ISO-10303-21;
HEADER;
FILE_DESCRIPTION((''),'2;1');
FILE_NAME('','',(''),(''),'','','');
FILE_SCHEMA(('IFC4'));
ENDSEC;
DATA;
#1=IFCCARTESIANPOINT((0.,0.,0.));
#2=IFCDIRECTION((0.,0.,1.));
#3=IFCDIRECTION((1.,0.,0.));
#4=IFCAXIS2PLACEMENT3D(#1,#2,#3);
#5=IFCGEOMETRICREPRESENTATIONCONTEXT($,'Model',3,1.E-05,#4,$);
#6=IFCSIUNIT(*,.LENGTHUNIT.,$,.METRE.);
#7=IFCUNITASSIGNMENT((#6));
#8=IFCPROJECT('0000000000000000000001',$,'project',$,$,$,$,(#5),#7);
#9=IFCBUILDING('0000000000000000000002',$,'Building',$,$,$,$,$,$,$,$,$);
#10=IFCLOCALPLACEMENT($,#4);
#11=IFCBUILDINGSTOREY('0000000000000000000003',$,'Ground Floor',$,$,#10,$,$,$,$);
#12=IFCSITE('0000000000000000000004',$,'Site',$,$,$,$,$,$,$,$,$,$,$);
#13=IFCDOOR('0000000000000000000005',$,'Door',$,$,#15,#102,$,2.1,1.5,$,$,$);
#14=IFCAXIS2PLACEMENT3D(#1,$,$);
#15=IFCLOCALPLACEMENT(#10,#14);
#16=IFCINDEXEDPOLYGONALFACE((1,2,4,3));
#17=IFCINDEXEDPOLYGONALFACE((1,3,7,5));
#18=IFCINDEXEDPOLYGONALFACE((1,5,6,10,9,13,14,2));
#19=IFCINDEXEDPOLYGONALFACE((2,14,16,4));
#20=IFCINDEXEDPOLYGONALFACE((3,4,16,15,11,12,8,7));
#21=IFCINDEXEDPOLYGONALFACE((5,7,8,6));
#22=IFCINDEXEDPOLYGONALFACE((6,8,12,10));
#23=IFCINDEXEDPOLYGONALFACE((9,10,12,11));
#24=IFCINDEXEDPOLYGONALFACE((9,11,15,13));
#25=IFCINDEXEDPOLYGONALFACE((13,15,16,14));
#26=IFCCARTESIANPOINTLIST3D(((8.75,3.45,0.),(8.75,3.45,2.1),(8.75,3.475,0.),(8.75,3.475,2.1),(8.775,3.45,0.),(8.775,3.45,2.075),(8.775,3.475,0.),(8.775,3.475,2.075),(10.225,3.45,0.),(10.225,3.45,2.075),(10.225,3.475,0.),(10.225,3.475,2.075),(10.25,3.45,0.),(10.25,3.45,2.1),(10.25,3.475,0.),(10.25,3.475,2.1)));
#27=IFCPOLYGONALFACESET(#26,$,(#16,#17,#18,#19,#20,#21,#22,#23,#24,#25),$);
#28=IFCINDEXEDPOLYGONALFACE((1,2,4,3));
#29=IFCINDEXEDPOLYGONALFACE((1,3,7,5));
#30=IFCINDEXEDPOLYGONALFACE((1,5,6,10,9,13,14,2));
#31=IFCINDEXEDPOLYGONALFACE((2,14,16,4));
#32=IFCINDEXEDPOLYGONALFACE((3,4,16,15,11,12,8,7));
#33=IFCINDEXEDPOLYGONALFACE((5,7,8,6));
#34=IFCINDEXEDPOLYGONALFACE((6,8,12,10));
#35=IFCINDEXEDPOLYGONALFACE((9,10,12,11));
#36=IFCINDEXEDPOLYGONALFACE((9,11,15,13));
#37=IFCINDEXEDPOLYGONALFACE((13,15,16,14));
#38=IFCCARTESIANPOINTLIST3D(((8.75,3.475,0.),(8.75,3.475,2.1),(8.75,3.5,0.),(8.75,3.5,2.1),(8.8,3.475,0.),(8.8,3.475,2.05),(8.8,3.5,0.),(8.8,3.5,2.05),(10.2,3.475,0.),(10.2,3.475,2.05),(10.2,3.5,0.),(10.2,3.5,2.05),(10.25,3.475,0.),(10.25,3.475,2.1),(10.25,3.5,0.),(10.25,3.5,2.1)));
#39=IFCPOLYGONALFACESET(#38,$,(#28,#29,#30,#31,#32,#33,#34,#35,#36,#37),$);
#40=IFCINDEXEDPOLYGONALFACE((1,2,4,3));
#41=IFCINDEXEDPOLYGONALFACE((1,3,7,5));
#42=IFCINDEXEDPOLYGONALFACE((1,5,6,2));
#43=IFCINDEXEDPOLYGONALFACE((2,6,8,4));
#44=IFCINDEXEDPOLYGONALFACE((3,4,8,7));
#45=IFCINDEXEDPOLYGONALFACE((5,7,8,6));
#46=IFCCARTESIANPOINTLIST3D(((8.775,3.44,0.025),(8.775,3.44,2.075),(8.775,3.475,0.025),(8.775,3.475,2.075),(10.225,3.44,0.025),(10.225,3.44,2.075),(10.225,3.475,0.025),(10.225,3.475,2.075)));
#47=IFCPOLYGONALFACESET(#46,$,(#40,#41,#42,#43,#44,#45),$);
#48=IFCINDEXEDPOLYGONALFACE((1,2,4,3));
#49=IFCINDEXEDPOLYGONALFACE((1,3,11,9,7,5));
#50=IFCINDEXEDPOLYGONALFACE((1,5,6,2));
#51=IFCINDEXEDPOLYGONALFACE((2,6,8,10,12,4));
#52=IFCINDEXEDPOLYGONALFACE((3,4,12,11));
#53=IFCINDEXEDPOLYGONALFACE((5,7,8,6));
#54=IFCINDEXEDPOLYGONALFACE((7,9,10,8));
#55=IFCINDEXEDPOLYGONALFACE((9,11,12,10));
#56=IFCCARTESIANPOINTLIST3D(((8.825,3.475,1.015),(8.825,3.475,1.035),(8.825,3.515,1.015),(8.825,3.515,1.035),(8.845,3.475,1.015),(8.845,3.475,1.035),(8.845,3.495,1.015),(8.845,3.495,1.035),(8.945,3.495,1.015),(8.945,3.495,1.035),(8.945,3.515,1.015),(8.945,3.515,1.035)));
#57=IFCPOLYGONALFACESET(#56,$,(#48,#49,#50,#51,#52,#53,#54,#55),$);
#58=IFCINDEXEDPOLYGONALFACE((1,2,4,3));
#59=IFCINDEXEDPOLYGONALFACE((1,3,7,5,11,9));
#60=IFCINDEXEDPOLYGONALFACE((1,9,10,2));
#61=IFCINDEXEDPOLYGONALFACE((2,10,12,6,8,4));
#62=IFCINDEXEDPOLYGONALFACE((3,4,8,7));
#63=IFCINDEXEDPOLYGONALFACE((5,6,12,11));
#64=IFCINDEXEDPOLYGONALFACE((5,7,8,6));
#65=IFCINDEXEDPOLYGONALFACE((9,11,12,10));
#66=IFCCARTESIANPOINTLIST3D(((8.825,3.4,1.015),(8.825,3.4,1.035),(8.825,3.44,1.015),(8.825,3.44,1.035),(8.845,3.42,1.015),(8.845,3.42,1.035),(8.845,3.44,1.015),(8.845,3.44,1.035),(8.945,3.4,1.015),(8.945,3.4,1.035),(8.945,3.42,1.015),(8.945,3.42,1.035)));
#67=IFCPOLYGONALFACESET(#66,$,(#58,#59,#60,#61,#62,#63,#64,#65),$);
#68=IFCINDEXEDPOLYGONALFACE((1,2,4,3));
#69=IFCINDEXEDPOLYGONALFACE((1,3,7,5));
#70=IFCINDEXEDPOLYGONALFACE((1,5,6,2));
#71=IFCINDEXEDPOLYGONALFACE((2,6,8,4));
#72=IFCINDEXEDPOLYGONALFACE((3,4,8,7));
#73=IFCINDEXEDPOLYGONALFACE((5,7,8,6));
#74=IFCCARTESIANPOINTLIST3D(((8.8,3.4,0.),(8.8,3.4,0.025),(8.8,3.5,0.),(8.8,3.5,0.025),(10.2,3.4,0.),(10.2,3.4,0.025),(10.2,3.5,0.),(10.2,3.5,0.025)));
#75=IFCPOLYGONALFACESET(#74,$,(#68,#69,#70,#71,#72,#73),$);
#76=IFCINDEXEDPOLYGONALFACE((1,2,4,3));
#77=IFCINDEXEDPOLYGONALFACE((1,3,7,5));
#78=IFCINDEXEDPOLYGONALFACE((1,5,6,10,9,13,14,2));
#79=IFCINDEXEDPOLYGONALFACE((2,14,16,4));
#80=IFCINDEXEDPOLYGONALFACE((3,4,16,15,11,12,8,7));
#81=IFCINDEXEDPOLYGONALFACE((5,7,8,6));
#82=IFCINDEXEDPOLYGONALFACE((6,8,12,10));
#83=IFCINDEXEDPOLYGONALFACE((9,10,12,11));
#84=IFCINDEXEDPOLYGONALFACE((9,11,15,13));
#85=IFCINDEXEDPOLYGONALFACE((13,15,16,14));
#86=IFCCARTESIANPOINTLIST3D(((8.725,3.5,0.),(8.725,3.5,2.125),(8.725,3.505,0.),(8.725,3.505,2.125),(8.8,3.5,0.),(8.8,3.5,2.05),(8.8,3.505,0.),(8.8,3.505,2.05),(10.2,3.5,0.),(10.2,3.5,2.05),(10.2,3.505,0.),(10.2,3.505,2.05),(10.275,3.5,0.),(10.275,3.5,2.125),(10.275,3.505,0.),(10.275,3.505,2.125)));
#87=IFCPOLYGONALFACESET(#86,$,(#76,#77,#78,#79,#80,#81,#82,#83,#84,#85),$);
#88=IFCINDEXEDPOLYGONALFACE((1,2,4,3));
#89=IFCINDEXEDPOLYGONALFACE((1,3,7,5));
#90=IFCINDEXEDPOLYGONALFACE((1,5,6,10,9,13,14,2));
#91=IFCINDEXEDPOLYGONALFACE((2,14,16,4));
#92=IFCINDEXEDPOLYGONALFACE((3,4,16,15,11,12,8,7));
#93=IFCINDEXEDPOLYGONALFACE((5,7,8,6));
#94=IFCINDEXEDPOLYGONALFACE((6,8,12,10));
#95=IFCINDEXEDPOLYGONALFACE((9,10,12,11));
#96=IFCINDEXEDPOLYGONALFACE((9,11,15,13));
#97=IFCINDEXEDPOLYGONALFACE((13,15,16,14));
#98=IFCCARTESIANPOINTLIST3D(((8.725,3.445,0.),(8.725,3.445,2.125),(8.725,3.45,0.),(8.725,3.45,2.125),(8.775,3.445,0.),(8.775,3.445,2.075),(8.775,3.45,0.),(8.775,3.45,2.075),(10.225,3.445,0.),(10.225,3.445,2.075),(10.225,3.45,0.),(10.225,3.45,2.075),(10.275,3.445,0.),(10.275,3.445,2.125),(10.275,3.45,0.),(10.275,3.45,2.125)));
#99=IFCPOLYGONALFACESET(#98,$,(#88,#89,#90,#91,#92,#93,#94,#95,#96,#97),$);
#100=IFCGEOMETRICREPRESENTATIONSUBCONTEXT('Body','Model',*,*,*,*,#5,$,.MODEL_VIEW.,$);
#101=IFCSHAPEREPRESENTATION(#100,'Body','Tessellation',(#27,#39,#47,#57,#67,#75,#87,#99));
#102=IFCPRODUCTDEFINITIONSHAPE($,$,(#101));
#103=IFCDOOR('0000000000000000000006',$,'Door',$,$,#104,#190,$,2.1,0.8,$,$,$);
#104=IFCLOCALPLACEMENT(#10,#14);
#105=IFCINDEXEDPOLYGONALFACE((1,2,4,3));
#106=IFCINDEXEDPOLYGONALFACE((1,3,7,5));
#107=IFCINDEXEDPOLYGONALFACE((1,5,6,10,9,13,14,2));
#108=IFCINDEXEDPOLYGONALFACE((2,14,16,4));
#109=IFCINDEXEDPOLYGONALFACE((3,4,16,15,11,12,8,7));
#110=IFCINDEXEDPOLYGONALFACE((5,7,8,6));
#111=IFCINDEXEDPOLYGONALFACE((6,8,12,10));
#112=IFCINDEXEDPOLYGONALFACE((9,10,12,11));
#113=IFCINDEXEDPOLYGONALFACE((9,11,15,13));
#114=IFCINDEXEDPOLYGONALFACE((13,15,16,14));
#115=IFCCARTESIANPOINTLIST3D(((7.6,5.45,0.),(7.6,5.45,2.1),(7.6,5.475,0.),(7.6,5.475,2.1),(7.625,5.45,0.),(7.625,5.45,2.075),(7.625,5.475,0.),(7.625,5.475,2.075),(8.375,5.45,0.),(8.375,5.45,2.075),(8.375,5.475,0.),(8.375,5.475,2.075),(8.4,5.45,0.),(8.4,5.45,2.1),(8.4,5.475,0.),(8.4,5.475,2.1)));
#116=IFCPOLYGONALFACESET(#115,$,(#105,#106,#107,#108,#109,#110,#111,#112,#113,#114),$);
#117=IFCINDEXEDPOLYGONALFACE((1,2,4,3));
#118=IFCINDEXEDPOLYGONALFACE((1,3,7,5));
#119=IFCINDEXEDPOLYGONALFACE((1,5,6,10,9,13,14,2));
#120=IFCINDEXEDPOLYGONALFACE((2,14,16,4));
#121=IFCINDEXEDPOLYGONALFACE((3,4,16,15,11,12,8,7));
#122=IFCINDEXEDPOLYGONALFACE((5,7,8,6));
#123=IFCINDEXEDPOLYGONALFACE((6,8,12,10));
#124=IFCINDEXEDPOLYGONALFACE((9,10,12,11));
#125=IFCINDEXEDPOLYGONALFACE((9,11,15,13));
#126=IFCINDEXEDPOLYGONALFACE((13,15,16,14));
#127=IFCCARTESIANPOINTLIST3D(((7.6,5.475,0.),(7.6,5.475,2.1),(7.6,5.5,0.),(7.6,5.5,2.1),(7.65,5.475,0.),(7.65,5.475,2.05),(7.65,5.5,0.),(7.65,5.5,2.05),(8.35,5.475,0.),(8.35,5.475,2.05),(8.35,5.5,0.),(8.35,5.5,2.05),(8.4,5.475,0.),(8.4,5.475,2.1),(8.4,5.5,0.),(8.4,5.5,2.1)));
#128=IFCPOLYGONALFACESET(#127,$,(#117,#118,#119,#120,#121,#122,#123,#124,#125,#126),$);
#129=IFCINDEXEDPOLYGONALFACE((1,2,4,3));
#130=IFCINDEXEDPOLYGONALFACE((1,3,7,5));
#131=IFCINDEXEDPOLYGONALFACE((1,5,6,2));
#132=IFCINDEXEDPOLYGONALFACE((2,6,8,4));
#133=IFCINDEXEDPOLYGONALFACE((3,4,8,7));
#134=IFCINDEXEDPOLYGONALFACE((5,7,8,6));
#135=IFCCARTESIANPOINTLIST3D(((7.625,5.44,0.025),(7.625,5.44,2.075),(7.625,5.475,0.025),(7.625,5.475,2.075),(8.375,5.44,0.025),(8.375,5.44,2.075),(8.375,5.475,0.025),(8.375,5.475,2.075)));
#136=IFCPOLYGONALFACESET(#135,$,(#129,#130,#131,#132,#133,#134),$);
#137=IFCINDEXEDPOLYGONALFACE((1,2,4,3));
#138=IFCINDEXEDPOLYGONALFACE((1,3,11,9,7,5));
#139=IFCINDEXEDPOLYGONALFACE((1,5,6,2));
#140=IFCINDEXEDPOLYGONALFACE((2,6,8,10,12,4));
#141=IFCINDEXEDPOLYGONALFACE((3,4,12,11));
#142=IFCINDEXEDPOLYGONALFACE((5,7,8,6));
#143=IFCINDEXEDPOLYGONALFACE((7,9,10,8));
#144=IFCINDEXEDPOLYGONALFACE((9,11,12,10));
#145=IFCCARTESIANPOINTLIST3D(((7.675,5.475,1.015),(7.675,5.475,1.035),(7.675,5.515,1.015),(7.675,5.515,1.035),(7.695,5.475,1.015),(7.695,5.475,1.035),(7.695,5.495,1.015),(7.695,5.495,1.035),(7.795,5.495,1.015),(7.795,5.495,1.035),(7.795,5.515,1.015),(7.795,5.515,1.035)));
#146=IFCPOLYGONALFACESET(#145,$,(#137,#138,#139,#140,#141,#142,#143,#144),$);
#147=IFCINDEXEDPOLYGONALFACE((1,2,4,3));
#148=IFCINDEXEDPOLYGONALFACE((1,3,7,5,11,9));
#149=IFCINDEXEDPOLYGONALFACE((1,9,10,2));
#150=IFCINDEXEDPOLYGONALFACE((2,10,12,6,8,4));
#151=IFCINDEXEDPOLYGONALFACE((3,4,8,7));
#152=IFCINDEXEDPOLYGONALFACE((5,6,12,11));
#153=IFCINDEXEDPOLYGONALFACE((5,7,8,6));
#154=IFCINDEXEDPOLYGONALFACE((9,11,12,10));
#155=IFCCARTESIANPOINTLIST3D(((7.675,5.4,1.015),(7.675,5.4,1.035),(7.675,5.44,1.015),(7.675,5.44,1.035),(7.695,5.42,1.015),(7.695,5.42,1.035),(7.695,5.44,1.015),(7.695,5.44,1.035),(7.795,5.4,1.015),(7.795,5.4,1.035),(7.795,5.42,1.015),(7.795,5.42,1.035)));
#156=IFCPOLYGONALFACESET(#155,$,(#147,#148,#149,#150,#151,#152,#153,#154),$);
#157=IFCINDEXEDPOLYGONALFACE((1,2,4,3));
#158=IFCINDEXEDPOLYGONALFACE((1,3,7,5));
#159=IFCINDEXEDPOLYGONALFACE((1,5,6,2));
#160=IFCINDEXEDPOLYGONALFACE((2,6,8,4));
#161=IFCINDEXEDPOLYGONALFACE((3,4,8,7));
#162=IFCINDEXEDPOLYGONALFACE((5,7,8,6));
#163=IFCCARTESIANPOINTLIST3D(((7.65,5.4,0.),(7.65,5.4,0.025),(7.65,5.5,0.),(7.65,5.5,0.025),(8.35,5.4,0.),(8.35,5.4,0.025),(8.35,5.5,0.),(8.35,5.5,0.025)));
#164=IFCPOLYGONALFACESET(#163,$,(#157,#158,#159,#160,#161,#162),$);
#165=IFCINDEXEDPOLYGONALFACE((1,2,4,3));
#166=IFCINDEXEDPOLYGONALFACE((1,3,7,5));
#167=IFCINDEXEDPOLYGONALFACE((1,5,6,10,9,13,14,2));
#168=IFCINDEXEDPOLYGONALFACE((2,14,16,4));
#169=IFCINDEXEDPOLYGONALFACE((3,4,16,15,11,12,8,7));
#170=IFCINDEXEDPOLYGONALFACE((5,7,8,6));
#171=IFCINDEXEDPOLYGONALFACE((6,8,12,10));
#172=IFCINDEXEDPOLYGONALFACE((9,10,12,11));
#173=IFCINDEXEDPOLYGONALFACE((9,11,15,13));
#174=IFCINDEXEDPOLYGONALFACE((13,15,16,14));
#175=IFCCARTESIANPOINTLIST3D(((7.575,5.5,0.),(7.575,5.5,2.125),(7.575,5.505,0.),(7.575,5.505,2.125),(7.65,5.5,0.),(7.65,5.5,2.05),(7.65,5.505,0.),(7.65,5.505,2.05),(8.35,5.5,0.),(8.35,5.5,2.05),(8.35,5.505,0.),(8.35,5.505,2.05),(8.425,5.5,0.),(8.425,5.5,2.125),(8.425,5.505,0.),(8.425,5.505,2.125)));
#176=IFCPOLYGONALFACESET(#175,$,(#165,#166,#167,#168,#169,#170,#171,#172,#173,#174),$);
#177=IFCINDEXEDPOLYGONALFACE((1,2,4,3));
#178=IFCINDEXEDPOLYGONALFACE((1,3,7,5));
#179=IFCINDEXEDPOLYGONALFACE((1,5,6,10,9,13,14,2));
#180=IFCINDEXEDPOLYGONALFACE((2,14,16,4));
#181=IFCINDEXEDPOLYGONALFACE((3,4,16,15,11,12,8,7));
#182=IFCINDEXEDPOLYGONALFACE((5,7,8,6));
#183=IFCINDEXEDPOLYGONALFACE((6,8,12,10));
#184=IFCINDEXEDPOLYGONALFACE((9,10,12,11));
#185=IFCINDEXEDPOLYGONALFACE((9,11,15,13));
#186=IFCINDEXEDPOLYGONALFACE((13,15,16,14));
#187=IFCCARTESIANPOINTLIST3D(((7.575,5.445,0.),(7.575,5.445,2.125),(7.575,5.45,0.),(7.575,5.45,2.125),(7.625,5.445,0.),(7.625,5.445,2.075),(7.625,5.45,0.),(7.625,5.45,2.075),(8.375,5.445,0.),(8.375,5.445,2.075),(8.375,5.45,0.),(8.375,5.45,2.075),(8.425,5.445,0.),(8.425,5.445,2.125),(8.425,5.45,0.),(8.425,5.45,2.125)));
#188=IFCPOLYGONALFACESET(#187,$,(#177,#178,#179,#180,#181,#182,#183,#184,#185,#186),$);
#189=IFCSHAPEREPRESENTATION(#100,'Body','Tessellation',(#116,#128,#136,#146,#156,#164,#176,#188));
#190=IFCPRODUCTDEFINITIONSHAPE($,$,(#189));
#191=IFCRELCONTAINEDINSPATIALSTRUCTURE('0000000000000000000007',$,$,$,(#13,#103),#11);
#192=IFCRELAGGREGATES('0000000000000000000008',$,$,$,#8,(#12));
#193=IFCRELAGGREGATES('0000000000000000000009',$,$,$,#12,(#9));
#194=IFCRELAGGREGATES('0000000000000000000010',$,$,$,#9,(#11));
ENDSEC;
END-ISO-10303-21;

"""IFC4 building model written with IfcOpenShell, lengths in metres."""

from ifc_helpers import new_model, si_unit, frame, origin_with_axes, place, context, subcontext, project, spatial, line, indexed_curve, outline, extrude, element, save


model = new_model("IFC4")

# Units and contexts
model_context = context("Model", 3, precision=1e-05, world=origin_with_axes())
body_context = subcontext(model_context, "Body", "Model", "MODEL_VIEW")
ifc_project = project(units=[si_unit("LENGTHUNIT", "METRE")], contexts=[model_context])

# Site, building, storey
site = spatial("IfcSite", under=ifc_project, Name="Site")
building = spatial("IfcBuilding", under=site, Name="Building")
storey_placement = place(None, origin_with_axes())
storey = spatial("IfcBuildingStorey", under=building, at=storey_placement, Name="Ground Floor")

# Doors
door_1_placement = place(storey_placement, frame((10.25, 3.5, 0.0), z_axis=(0.0, 0.0, 1.0), x_axis=(-1.0, 0.0, 0.0)))
element("IfcDoor", 1, at=door_1_placement, inside=storey, Name="Door", OverallHeight=2.1, OverallWidth=1.5, context=body_context, shape_type="SweptSolid", body=[
    extrude(outline(indexed_curve([(0.0, 0.0), (0.0, 2.1), (1.5, 2.1), (1.5, 0.0), (1.475, 0.0), (1.475, 2.075), (0.025, 2.075), (0.025, 0.0)], segments=[line(1, 2, 3, 4, 5, 6, 7, 8, 1)])), frame((0.0, 0.025, 0.0), z_axis=(0.0, -1.0, 0.0), x_axis=(1.0, 0.0, 0.0)), (0.0, 0.0, -1.0), 0.025),
    extrude(outline(indexed_curve([(0.0, 0.0), (0.0, 2.1), (1.5, 2.1), (1.5, 0.0), (1.45, 0.0), (1.45, 2.05), (0.05, 2.05), (0.05, 0.0)], segments=[line(1, 2, 3, 4, 5, 6, 7, 8, 1)])), frame((0.0, 0.0, 0.0), z_axis=(0.0, -1.0, 0.0), x_axis=(1.0, 0.0, 0.0)), (0.0, 0.0, -1.0), 0.025),
    extrude(outline(indexed_curve([(0.0, 0.0), (1.45, 0.0), (1.45, 0.035), (0.0, 0.035)], segments=[line(1, 2, 3, 4, 1)])), frame((0.025, 0.025, 0.025), z_axis=(0.0, 0.0, 1.0), x_axis=(1.0, 0.0, 0.0)), (0.0, 0.0, 1.0), 2.05),
    extrude(outline(indexed_curve([(0.0, 0.0), (0.0, -0.04), (-0.12, -0.04), (-0.12, -0.02), (-0.02, -0.02), (-0.02, 0.0)], segments=[line(1, 2, 3, 4, 5, 6, 1)])), frame((1.425, 0.025, 1.015), z_axis=(0.0, 0.0, 1.0), x_axis=(1.0, 0.0, 0.0)), (0.0, 0.0, 1.0), 0.02),
    extrude(outline(indexed_curve([(0.0, 0.0), (0.0, 0.04), (-0.12, 0.04), (-0.12, 0.02), (-0.02, 0.02), (-0.02, 0.0)], segments=[line(1, 2, 3, 4, 5, 6, 1)])), frame((1.425, 0.06, 1.015), z_axis=(0.0, 0.0, 1.0), x_axis=(1.0, 0.0, 0.0)), (0.0, 0.0, 1.0), 0.02),
    extrude(outline(indexed_curve([(0.0, 0.0), (1.4, 0.0), (1.4, 0.1), (0.0, 0.1)], segments=[line(1, 2, 3, 4, 1)])), frame((0.05, 0.0, 0.0), z_axis=(0.0, 0.0, 1.0), x_axis=(1.0, 0.0, 0.0)), (0.0, 0.0, 1.0), 0.025),
    extrude(outline(indexed_curve([(0.0, 0.0), (0.0, 2.125), (1.55, 2.125), (1.55, 0.0), (1.475, 0.0), (1.475, 2.05), (0.075, 2.05), (0.075, 0.0)], segments=[line(1, 2, 3, 4, 5, 6, 7, 8, 1)])), frame((-0.025, -0.005, 0.0), z_axis=(0.0, -1.0, 0.0), x_axis=(1.0, 0.0, 0.0)), (0.0, 0.0, -1.0), 0.005),
    extrude(outline(indexed_curve([(0.0, 0.0), (0.0, 2.125), (1.55, 2.125), (1.55, 0.0), (1.5, 0.0), (1.5, 2.075), (0.05, 2.075), (0.05, 0.0)], segments=[line(1, 2, 3, 4, 5, 6, 7, 8, 1)])), frame((-0.025, 0.05, 0.0), z_axis=(0.0, -1.0, 0.0), x_axis=(1.0, 0.0, 0.0)), (0.0, 0.0, -1.0), 0.005),
])
door_2_placement = place(storey_placement, frame((8.4, 5.5, 0.0), z_axis=(0.0, 0.0, 1.0), x_axis=(-1.0, 0.0, 0.0)))
element("IfcDoor", 2, at=door_2_placement, inside=storey, Name="Door", OverallHeight=2.1, OverallWidth=0.8, context=body_context, shape_type="SweptSolid", body=[
    extrude(outline(indexed_curve([(0.0, 0.0), (0.0, 2.1), (0.8, 2.1), (0.8, 0.0), (0.775, 0.0), (0.775, 2.075), (0.025, 2.075), (0.025, 0.0)], segments=[line(1, 2, 3, 4, 5, 6, 7, 8, 1)])), frame((0.0, 0.025, 0.0), z_axis=(0.0, -1.0, 0.0), x_axis=(1.0, 0.0, 0.0)), (0.0, 0.0, -1.0), 0.025),
    extrude(outline(indexed_curve([(0.0, 0.0), (0.0, 2.1), (0.8, 2.1), (0.8, 0.0), (0.75, 0.0), (0.75, 2.05), (0.05, 2.05), (0.05, 0.0)], segments=[line(1, 2, 3, 4, 5, 6, 7, 8, 1)])), frame((0.0, 0.0, 0.0), z_axis=(0.0, -1.0, 0.0), x_axis=(1.0, 0.0, 0.0)), (0.0, 0.0, -1.0), 0.025),
    extrude(outline(indexed_curve([(0.0, 0.0), (0.75, 0.0), (0.75, 0.035), (0.0, 0.035)], segments=[line(1, 2, 3, 4, 1)])), frame((0.025, 0.025, 0.025), z_axis=(0.0, 0.0, 1.0), x_axis=(1.0, 0.0, 0.0)), (0.0, 0.0, 1.0), 2.05),
    extrude(outline(indexed_curve([(0.0, 0.0), (0.0, -0.04), (-0.12, -0.04), (-0.12, -0.02), (-0.02, -0.02), (-0.02, 0.0)], segments=[line(1, 2, 3, 4, 5, 6, 1)])), frame((0.725, 0.025, 1.015), z_axis=(0.0, 0.0, 1.0), x_axis=(1.0, 0.0, 0.0)), (0.0, 0.0, 1.0), 0.02),
    extrude(outline(indexed_curve([(0.0, 0.0), (0.0, 0.04), (-0.12, 0.04), (-0.12, 0.02), (-0.02, 0.02), (-0.02, 0.0)], segments=[line(1, 2, 3, 4, 5, 6, 1)])), frame((0.725, 0.06, 1.015), z_axis=(0.0, 0.0, 1.0), x_axis=(1.0, 0.0, 0.0)), (0.0, 0.0, 1.0), 0.02),
    extrude(outline(indexed_curve([(0.0, 0.0), (0.7, 0.0), (0.7, 0.1), (0.0, 0.1)], segments=[line(1, 2, 3, 4, 1)])), frame((0.05, 0.0, 0.0), z_axis=(0.0, 0.0, 1.0), x_axis=(1.0, 0.0, 0.0)), (0.0, 0.0, 1.0), 0.025),
    extrude(outline(indexed_curve([(0.0, 0.0), (0.0, 2.125), (0.85, 2.125), (0.85, 0.0), (0.775, 0.0), (0.775, 2.05), (0.075, 2.05), (0.075, 0.0)], segments=[line(1, 2, 3, 4, 5, 6, 7, 8, 1)])), frame((-0.025, -0.005, 0.0), z_axis=(0.0, -1.0, 0.0), x_axis=(1.0, 0.0, 0.0)), (0.0, 0.0, -1.0), 0.005),
    extrude(outline(indexed_curve([(0.0, 0.0), (0.0, 2.125), (0.85, 2.125), (0.85, 0.0), (0.8, 0.0), (0.8, 2.075), (0.05, 2.075), (0.05, 0.0)], segments=[line(1, 2, 3, 4, 5, 6, 7, 8, 1)])), frame((-0.025, 0.05, 0.0), z_axis=(0.0, -1.0, 0.0), x_axis=(1.0, 0.0, 0.0)), (0.0, 0.0, -1.0), 0.005),
])

save(model, "model.ifc")
